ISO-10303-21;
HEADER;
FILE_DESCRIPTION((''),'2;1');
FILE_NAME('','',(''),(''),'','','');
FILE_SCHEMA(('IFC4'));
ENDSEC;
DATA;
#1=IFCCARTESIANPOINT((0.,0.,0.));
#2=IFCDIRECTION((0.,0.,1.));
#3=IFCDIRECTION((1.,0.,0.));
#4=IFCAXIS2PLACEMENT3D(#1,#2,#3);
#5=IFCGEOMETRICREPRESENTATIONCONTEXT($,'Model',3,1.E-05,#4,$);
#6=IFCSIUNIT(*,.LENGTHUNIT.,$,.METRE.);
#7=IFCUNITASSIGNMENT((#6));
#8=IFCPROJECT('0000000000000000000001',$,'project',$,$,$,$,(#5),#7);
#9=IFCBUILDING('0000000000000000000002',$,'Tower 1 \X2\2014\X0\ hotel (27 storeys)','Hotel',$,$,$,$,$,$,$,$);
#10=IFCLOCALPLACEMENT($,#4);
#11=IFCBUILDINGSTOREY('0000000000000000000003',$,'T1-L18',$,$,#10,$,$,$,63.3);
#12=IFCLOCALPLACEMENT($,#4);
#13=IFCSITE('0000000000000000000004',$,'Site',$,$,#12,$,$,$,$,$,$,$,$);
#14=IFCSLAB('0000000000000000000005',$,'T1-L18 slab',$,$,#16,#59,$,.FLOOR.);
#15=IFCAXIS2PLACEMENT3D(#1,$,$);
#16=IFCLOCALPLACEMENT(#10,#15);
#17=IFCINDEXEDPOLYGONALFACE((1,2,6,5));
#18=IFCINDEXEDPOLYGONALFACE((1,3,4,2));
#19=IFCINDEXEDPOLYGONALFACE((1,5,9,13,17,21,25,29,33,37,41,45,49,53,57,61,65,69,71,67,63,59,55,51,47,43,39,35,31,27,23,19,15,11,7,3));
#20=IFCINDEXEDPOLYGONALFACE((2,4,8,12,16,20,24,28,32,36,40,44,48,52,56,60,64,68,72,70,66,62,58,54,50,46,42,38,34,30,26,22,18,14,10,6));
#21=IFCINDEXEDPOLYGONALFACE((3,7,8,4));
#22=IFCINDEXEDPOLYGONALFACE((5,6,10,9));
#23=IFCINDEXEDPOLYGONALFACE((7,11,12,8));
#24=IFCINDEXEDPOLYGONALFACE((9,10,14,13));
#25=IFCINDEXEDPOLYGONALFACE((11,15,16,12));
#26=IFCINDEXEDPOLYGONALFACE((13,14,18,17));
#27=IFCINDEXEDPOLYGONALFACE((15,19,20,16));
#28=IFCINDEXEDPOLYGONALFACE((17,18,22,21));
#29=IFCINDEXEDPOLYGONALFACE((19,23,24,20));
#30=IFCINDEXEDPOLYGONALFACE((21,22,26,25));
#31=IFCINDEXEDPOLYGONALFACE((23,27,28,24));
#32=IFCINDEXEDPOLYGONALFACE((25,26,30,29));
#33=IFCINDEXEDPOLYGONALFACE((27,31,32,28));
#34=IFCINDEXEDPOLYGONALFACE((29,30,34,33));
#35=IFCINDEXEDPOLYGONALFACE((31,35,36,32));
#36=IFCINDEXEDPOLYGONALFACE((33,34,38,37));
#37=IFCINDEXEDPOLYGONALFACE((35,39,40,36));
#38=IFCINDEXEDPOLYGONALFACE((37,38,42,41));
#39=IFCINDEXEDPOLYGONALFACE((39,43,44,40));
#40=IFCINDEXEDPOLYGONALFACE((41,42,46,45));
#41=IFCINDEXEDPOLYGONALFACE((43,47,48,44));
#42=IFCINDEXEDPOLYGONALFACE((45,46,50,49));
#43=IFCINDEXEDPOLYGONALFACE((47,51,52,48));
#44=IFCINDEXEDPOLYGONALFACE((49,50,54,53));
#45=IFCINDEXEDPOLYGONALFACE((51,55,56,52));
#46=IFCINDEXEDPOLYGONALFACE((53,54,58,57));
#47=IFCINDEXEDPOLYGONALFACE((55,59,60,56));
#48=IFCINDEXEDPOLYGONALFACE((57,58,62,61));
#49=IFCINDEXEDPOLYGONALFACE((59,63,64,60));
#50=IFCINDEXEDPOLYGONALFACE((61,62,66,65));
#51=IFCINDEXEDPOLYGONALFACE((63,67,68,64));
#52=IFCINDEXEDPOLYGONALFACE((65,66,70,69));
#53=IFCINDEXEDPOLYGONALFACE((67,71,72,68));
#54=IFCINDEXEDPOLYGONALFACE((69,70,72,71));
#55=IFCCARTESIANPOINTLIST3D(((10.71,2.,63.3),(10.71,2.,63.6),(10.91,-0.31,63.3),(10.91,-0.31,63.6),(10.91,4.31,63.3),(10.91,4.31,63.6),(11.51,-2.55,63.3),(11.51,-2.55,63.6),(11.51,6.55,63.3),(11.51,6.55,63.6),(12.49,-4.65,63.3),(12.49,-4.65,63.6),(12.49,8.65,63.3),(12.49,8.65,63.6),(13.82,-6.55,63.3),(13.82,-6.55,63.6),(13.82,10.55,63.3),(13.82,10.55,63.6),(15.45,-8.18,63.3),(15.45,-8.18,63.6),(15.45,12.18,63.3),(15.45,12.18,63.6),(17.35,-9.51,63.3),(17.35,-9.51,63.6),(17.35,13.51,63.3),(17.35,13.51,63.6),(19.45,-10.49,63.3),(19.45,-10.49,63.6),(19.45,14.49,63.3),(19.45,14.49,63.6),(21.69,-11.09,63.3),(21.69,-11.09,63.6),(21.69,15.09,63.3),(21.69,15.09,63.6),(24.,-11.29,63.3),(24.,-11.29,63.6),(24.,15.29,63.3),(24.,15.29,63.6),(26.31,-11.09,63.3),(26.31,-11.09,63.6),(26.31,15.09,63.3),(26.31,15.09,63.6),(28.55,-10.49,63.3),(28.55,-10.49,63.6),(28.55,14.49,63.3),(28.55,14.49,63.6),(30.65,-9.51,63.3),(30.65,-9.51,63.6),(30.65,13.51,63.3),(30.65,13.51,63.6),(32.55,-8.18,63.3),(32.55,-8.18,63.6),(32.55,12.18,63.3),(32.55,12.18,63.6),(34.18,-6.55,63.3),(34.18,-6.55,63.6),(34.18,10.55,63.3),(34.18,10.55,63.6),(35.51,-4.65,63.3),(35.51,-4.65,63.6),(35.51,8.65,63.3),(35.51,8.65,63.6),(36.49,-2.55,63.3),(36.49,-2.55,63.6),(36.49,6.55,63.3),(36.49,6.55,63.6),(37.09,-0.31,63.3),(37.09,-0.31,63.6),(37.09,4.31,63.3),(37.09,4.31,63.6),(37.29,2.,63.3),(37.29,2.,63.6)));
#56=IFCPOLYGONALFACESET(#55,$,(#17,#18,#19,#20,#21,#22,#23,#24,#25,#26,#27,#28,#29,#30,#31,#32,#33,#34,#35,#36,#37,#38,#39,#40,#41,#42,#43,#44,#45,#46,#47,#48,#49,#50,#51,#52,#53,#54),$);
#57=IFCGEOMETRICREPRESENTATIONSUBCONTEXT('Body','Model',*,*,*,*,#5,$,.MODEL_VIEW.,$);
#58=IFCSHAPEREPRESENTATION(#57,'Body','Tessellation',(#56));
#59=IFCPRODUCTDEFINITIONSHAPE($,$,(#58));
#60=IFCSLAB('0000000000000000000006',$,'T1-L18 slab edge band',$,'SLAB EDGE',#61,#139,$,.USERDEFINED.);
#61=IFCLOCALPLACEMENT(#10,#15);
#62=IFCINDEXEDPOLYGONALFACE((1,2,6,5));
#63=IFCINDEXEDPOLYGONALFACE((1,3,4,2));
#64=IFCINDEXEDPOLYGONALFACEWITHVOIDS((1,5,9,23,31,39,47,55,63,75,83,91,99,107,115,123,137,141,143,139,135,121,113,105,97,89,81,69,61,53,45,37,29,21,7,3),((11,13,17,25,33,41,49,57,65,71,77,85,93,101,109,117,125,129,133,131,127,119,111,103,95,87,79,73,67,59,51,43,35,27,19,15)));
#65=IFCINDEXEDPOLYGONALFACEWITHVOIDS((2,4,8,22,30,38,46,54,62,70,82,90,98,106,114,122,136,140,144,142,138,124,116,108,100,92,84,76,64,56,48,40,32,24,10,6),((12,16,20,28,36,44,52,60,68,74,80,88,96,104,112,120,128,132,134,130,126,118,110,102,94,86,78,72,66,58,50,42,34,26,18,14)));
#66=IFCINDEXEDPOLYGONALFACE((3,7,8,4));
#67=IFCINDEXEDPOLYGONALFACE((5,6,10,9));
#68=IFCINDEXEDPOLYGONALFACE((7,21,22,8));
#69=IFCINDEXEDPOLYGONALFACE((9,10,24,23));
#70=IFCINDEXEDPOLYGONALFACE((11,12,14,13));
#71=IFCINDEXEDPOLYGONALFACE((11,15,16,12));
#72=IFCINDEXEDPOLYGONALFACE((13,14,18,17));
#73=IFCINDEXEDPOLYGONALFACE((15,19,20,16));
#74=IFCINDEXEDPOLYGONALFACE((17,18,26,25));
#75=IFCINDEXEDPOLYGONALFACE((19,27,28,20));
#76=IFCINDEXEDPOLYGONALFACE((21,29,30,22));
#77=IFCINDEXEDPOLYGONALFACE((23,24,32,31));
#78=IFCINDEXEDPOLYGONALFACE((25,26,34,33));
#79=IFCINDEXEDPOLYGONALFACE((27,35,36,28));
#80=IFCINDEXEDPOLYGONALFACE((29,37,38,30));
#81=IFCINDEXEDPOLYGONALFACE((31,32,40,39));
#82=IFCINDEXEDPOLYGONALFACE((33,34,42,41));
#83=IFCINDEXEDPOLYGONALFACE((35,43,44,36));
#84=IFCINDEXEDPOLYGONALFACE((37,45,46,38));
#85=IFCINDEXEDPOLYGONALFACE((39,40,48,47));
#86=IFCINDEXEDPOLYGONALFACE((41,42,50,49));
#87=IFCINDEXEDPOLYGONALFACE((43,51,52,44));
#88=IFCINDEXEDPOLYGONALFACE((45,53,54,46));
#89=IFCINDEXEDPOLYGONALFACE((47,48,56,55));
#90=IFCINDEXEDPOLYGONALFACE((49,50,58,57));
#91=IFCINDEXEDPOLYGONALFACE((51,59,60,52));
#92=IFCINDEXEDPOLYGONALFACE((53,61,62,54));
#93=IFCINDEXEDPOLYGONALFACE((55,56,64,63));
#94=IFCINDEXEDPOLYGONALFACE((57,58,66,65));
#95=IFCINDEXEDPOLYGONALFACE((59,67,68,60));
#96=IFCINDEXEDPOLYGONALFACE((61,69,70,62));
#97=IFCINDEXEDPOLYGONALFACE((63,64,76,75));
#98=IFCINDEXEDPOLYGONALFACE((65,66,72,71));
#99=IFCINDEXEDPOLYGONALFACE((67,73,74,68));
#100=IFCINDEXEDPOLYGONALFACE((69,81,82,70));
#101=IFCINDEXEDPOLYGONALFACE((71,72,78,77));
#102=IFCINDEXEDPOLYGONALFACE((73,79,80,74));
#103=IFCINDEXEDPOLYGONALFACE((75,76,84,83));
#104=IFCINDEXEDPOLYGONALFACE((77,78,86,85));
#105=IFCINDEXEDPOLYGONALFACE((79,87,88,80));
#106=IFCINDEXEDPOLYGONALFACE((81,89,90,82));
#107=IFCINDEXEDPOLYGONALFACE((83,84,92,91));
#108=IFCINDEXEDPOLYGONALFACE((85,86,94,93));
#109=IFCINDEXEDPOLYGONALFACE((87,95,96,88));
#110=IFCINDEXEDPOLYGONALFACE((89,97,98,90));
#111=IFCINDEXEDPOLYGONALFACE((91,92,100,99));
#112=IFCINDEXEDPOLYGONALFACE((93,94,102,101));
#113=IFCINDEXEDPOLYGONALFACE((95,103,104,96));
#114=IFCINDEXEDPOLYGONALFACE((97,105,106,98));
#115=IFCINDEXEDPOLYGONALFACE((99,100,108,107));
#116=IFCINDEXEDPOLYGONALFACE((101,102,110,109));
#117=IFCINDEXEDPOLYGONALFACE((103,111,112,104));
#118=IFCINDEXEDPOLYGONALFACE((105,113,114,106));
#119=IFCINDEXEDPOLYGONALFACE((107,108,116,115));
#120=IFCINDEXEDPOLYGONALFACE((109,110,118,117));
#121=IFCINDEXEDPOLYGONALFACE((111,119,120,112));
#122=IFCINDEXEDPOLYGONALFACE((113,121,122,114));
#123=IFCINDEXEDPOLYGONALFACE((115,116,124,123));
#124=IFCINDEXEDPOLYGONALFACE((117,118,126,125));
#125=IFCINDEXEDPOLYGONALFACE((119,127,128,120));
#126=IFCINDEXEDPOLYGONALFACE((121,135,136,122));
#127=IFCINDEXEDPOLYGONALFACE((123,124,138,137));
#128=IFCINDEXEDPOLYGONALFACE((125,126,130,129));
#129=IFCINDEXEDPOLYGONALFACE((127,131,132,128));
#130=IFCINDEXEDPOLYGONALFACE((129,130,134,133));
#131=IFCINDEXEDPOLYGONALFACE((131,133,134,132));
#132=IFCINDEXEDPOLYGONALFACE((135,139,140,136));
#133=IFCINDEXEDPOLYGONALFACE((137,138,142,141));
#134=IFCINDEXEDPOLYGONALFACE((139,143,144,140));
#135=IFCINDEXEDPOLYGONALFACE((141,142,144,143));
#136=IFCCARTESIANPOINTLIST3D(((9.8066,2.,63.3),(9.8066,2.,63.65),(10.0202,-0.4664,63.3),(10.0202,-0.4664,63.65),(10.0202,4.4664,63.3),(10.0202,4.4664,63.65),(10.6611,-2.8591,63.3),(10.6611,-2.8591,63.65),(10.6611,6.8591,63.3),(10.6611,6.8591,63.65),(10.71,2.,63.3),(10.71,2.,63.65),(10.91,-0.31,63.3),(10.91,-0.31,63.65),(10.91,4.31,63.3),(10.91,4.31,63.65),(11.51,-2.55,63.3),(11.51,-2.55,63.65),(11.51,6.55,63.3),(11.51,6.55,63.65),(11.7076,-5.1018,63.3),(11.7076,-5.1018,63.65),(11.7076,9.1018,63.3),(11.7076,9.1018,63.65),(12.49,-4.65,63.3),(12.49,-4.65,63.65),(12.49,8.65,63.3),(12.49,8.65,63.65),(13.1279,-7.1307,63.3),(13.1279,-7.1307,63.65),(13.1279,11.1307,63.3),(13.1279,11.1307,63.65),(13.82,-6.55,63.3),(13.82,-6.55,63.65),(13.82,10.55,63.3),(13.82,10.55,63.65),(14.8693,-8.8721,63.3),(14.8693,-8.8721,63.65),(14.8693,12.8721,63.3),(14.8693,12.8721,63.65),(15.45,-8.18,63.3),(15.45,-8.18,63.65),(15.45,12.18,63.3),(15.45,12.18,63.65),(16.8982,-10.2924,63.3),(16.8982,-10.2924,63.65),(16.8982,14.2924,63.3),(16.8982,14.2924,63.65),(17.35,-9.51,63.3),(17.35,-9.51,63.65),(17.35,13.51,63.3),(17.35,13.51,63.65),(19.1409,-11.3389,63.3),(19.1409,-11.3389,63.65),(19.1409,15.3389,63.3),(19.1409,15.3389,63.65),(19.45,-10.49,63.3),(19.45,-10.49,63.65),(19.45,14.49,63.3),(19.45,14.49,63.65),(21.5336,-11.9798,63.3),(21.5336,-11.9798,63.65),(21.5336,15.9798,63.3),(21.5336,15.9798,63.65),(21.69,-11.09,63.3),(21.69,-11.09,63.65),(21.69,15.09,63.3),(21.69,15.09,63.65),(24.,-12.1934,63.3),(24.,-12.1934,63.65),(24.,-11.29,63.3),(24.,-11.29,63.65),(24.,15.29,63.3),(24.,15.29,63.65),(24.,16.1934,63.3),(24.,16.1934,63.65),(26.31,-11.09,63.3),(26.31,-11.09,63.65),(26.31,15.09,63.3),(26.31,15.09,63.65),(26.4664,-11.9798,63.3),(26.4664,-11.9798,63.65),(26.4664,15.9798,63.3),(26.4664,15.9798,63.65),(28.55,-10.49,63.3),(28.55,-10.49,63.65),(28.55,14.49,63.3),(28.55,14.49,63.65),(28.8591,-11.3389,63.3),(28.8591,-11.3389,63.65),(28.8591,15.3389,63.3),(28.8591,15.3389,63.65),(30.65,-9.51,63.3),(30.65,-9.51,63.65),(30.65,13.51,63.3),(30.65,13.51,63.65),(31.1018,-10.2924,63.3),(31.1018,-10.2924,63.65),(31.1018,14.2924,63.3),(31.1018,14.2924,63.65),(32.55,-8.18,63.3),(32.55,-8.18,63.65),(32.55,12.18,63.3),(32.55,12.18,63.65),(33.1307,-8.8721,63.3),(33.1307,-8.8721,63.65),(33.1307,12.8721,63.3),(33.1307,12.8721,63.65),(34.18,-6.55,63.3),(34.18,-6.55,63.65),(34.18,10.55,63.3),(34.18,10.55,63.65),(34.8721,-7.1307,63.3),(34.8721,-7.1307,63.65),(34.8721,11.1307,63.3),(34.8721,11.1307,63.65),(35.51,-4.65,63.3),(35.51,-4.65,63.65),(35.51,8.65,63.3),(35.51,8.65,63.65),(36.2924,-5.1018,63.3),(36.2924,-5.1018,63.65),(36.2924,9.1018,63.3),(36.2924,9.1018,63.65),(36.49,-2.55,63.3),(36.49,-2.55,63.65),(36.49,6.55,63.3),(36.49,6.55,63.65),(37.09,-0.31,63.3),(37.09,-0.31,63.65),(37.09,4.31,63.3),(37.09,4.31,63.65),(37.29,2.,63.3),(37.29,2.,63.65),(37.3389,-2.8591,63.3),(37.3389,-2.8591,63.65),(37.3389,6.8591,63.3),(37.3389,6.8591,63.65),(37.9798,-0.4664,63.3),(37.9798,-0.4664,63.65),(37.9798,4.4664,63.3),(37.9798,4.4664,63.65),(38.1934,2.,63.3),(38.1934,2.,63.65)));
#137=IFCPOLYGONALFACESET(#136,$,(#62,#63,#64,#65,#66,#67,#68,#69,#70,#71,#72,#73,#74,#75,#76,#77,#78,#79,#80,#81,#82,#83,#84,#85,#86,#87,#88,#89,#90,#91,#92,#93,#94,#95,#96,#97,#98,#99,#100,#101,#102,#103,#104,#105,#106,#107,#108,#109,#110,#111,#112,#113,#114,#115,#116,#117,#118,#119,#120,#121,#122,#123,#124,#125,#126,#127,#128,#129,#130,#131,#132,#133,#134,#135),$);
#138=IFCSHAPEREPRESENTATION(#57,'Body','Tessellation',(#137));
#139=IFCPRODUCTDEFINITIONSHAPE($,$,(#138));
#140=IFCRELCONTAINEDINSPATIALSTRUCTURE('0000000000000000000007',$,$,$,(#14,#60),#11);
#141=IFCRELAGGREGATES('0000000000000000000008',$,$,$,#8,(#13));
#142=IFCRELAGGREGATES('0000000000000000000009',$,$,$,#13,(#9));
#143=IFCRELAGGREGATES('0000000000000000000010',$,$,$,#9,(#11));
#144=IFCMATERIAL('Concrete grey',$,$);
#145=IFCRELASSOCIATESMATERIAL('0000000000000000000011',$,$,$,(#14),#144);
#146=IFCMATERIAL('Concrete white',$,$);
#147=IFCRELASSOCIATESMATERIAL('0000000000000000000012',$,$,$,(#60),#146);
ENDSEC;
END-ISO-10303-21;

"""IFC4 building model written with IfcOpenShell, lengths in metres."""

from ifc_helpers import new_model, si_unit, frame, origin_with_axes, place, context, subcontext, project, spatial, polyline, outline, extrude, material, element, save


model = new_model("IFC4")

# Units and contexts
model_context = context("Model", 3, precision=1e-05, world=origin_with_axes())
body_context = subcontext(model_context, "Body", "Model", "MODEL_VIEW")
ifc_project = project(units=[si_unit("LENGTHUNIT", "METRE")], contexts=[model_context])

# Site, building, storey
site_placement = place(None, origin_with_axes())
site = spatial("IfcSite", under=ifc_project, at=site_placement, Name="Site")
building = spatial("IfcBuilding", under=site, Name="Tower 1 — hotel (27 storeys)", Description="Hotel")
storey_placement = place(None, origin_with_axes())
storey = spatial("IfcBuildingStorey", under=building, at=storey_placement, Name="T1-L18", Elevation=63.3)

# Slab
ifc_material_1 = material(Name="Concrete grey")
slab_1_placement = place(storey_placement, origin_with_axes())
element("IfcSlab", 1, at=slab_1_placement, inside=storey, material=ifc_material_1, Name="T1-L18 slab", PredefinedType="FLOOR", context=body_context, shape_type="SweptSolid", body=[
    extrude(outline(polyline([(37.29, 2.0), (37.09, 4.31), (36.49, 6.55), (35.51, 8.65), (34.18, 10.55), (32.55, 12.18), (30.65, 13.51), (28.55, 14.49), (26.31, 15.09), (24.0, 15.29), (21.69, 15.09), (19.45, 14.49), (17.35, 13.51), (15.45, 12.18), (13.82, 10.55), (12.49, 8.65), (11.51, 6.55), (10.91, 4.31), (10.71, 2.0), (10.91, -0.31), (11.51, -2.55), (12.49, -4.65), (13.82, -6.55), (15.45, -8.18), (17.35, -9.51), (19.45, -10.49), (21.69, -11.09), (24.0, -11.29), (26.31, -11.09), (28.55, -10.49), (30.65, -9.51), (32.55, -8.18), (34.18, -6.55), (35.51, -4.65), (36.49, -2.55), (37.09, -0.31), (37.29, 2.0)])), frame((0.0, 0.0, 63.3), z_axis=(0.0, 0.0, 1.0), x_axis=(1.0, 0.0, 0.0)), (0.0, 0.0, 1.0), 0.3),
])

# Slab
ifc_material_2 = material(Name="Concrete white")
slab_2_placement = place(storey_placement, origin_with_axes())
element("IfcSlab", 2, at=slab_2_placement, inside=storey, material=ifc_material_2, Name="T1-L18 slab edge band", ObjectType="SLAB EDGE", PredefinedType="USERDEFINED", context=body_context, shape_type="SweptSolid", body=[
    extrude(outline(polyline([(38.1934, 2.0), (37.9798, 4.4664), (37.3389, 6.8591), (36.2924, 9.1018), (34.8721, 11.1307), (33.1307, 12.8721), (31.1018, 14.2924), (28.8591, 15.3389), (26.4664, 15.9798), (24.0, 16.1934), (21.5336, 15.9798), (19.1409, 15.3389), (16.8982, 14.2924), (14.8693, 12.8721), (13.1279, 11.1307), (11.7076, 9.1018), (10.6611, 6.8591), (10.0202, 4.4664), (9.8066, 2.0), (10.0202, -0.4664), (10.6611, -2.8591), (11.7076, -5.1018), (13.1279, -7.1307), (14.8693, -8.8721), (16.8982, -10.2924), (19.1409, -11.3389), (21.5336, -11.9798), (24.0, -12.1934), (26.4664, -11.9798), (28.8591, -11.3389), (31.1018, -10.2924), (33.1307, -8.8721), (34.8721, -7.1307), (36.2924, -5.1018), (37.3389, -2.8591), (37.9798, -0.4664), (38.1934, 2.0)]), holes=[polyline([(37.29, 2.0), (37.09, 4.31), (36.49, 6.55), (35.51, 8.65), (34.18, 10.55), (32.55, 12.18), (30.65, 13.51), (28.55, 14.49), (26.31, 15.09), (24.0, 15.29), (21.69, 15.09), (19.45, 14.49), (17.35, 13.51), (15.45, 12.18), (13.82, 10.55), (12.49, 8.65), (11.51, 6.55), (10.91, 4.31), (10.71, 2.0), (10.91, -0.31), (11.51, -2.55), (12.49, -4.65), (13.82, -6.55), (15.45, -8.18), (17.35, -9.51), (19.45, -10.49), (21.69, -11.09), (24.0, -11.29), (26.31, -11.09), (28.55, -10.49), (30.65, -9.51), (32.55, -8.18), (34.18, -6.55), (35.51, -4.65), (36.49, -2.55), (37.09, -0.31), (37.29, 2.0)])]), frame((0.0, 0.0, 63.3), z_axis=(0.0, 0.0, 1.0), x_axis=(1.0, 0.0, 0.0)), (0.0, 0.0, 1.0), 0.35),
])

save(model, "model.ifc")
